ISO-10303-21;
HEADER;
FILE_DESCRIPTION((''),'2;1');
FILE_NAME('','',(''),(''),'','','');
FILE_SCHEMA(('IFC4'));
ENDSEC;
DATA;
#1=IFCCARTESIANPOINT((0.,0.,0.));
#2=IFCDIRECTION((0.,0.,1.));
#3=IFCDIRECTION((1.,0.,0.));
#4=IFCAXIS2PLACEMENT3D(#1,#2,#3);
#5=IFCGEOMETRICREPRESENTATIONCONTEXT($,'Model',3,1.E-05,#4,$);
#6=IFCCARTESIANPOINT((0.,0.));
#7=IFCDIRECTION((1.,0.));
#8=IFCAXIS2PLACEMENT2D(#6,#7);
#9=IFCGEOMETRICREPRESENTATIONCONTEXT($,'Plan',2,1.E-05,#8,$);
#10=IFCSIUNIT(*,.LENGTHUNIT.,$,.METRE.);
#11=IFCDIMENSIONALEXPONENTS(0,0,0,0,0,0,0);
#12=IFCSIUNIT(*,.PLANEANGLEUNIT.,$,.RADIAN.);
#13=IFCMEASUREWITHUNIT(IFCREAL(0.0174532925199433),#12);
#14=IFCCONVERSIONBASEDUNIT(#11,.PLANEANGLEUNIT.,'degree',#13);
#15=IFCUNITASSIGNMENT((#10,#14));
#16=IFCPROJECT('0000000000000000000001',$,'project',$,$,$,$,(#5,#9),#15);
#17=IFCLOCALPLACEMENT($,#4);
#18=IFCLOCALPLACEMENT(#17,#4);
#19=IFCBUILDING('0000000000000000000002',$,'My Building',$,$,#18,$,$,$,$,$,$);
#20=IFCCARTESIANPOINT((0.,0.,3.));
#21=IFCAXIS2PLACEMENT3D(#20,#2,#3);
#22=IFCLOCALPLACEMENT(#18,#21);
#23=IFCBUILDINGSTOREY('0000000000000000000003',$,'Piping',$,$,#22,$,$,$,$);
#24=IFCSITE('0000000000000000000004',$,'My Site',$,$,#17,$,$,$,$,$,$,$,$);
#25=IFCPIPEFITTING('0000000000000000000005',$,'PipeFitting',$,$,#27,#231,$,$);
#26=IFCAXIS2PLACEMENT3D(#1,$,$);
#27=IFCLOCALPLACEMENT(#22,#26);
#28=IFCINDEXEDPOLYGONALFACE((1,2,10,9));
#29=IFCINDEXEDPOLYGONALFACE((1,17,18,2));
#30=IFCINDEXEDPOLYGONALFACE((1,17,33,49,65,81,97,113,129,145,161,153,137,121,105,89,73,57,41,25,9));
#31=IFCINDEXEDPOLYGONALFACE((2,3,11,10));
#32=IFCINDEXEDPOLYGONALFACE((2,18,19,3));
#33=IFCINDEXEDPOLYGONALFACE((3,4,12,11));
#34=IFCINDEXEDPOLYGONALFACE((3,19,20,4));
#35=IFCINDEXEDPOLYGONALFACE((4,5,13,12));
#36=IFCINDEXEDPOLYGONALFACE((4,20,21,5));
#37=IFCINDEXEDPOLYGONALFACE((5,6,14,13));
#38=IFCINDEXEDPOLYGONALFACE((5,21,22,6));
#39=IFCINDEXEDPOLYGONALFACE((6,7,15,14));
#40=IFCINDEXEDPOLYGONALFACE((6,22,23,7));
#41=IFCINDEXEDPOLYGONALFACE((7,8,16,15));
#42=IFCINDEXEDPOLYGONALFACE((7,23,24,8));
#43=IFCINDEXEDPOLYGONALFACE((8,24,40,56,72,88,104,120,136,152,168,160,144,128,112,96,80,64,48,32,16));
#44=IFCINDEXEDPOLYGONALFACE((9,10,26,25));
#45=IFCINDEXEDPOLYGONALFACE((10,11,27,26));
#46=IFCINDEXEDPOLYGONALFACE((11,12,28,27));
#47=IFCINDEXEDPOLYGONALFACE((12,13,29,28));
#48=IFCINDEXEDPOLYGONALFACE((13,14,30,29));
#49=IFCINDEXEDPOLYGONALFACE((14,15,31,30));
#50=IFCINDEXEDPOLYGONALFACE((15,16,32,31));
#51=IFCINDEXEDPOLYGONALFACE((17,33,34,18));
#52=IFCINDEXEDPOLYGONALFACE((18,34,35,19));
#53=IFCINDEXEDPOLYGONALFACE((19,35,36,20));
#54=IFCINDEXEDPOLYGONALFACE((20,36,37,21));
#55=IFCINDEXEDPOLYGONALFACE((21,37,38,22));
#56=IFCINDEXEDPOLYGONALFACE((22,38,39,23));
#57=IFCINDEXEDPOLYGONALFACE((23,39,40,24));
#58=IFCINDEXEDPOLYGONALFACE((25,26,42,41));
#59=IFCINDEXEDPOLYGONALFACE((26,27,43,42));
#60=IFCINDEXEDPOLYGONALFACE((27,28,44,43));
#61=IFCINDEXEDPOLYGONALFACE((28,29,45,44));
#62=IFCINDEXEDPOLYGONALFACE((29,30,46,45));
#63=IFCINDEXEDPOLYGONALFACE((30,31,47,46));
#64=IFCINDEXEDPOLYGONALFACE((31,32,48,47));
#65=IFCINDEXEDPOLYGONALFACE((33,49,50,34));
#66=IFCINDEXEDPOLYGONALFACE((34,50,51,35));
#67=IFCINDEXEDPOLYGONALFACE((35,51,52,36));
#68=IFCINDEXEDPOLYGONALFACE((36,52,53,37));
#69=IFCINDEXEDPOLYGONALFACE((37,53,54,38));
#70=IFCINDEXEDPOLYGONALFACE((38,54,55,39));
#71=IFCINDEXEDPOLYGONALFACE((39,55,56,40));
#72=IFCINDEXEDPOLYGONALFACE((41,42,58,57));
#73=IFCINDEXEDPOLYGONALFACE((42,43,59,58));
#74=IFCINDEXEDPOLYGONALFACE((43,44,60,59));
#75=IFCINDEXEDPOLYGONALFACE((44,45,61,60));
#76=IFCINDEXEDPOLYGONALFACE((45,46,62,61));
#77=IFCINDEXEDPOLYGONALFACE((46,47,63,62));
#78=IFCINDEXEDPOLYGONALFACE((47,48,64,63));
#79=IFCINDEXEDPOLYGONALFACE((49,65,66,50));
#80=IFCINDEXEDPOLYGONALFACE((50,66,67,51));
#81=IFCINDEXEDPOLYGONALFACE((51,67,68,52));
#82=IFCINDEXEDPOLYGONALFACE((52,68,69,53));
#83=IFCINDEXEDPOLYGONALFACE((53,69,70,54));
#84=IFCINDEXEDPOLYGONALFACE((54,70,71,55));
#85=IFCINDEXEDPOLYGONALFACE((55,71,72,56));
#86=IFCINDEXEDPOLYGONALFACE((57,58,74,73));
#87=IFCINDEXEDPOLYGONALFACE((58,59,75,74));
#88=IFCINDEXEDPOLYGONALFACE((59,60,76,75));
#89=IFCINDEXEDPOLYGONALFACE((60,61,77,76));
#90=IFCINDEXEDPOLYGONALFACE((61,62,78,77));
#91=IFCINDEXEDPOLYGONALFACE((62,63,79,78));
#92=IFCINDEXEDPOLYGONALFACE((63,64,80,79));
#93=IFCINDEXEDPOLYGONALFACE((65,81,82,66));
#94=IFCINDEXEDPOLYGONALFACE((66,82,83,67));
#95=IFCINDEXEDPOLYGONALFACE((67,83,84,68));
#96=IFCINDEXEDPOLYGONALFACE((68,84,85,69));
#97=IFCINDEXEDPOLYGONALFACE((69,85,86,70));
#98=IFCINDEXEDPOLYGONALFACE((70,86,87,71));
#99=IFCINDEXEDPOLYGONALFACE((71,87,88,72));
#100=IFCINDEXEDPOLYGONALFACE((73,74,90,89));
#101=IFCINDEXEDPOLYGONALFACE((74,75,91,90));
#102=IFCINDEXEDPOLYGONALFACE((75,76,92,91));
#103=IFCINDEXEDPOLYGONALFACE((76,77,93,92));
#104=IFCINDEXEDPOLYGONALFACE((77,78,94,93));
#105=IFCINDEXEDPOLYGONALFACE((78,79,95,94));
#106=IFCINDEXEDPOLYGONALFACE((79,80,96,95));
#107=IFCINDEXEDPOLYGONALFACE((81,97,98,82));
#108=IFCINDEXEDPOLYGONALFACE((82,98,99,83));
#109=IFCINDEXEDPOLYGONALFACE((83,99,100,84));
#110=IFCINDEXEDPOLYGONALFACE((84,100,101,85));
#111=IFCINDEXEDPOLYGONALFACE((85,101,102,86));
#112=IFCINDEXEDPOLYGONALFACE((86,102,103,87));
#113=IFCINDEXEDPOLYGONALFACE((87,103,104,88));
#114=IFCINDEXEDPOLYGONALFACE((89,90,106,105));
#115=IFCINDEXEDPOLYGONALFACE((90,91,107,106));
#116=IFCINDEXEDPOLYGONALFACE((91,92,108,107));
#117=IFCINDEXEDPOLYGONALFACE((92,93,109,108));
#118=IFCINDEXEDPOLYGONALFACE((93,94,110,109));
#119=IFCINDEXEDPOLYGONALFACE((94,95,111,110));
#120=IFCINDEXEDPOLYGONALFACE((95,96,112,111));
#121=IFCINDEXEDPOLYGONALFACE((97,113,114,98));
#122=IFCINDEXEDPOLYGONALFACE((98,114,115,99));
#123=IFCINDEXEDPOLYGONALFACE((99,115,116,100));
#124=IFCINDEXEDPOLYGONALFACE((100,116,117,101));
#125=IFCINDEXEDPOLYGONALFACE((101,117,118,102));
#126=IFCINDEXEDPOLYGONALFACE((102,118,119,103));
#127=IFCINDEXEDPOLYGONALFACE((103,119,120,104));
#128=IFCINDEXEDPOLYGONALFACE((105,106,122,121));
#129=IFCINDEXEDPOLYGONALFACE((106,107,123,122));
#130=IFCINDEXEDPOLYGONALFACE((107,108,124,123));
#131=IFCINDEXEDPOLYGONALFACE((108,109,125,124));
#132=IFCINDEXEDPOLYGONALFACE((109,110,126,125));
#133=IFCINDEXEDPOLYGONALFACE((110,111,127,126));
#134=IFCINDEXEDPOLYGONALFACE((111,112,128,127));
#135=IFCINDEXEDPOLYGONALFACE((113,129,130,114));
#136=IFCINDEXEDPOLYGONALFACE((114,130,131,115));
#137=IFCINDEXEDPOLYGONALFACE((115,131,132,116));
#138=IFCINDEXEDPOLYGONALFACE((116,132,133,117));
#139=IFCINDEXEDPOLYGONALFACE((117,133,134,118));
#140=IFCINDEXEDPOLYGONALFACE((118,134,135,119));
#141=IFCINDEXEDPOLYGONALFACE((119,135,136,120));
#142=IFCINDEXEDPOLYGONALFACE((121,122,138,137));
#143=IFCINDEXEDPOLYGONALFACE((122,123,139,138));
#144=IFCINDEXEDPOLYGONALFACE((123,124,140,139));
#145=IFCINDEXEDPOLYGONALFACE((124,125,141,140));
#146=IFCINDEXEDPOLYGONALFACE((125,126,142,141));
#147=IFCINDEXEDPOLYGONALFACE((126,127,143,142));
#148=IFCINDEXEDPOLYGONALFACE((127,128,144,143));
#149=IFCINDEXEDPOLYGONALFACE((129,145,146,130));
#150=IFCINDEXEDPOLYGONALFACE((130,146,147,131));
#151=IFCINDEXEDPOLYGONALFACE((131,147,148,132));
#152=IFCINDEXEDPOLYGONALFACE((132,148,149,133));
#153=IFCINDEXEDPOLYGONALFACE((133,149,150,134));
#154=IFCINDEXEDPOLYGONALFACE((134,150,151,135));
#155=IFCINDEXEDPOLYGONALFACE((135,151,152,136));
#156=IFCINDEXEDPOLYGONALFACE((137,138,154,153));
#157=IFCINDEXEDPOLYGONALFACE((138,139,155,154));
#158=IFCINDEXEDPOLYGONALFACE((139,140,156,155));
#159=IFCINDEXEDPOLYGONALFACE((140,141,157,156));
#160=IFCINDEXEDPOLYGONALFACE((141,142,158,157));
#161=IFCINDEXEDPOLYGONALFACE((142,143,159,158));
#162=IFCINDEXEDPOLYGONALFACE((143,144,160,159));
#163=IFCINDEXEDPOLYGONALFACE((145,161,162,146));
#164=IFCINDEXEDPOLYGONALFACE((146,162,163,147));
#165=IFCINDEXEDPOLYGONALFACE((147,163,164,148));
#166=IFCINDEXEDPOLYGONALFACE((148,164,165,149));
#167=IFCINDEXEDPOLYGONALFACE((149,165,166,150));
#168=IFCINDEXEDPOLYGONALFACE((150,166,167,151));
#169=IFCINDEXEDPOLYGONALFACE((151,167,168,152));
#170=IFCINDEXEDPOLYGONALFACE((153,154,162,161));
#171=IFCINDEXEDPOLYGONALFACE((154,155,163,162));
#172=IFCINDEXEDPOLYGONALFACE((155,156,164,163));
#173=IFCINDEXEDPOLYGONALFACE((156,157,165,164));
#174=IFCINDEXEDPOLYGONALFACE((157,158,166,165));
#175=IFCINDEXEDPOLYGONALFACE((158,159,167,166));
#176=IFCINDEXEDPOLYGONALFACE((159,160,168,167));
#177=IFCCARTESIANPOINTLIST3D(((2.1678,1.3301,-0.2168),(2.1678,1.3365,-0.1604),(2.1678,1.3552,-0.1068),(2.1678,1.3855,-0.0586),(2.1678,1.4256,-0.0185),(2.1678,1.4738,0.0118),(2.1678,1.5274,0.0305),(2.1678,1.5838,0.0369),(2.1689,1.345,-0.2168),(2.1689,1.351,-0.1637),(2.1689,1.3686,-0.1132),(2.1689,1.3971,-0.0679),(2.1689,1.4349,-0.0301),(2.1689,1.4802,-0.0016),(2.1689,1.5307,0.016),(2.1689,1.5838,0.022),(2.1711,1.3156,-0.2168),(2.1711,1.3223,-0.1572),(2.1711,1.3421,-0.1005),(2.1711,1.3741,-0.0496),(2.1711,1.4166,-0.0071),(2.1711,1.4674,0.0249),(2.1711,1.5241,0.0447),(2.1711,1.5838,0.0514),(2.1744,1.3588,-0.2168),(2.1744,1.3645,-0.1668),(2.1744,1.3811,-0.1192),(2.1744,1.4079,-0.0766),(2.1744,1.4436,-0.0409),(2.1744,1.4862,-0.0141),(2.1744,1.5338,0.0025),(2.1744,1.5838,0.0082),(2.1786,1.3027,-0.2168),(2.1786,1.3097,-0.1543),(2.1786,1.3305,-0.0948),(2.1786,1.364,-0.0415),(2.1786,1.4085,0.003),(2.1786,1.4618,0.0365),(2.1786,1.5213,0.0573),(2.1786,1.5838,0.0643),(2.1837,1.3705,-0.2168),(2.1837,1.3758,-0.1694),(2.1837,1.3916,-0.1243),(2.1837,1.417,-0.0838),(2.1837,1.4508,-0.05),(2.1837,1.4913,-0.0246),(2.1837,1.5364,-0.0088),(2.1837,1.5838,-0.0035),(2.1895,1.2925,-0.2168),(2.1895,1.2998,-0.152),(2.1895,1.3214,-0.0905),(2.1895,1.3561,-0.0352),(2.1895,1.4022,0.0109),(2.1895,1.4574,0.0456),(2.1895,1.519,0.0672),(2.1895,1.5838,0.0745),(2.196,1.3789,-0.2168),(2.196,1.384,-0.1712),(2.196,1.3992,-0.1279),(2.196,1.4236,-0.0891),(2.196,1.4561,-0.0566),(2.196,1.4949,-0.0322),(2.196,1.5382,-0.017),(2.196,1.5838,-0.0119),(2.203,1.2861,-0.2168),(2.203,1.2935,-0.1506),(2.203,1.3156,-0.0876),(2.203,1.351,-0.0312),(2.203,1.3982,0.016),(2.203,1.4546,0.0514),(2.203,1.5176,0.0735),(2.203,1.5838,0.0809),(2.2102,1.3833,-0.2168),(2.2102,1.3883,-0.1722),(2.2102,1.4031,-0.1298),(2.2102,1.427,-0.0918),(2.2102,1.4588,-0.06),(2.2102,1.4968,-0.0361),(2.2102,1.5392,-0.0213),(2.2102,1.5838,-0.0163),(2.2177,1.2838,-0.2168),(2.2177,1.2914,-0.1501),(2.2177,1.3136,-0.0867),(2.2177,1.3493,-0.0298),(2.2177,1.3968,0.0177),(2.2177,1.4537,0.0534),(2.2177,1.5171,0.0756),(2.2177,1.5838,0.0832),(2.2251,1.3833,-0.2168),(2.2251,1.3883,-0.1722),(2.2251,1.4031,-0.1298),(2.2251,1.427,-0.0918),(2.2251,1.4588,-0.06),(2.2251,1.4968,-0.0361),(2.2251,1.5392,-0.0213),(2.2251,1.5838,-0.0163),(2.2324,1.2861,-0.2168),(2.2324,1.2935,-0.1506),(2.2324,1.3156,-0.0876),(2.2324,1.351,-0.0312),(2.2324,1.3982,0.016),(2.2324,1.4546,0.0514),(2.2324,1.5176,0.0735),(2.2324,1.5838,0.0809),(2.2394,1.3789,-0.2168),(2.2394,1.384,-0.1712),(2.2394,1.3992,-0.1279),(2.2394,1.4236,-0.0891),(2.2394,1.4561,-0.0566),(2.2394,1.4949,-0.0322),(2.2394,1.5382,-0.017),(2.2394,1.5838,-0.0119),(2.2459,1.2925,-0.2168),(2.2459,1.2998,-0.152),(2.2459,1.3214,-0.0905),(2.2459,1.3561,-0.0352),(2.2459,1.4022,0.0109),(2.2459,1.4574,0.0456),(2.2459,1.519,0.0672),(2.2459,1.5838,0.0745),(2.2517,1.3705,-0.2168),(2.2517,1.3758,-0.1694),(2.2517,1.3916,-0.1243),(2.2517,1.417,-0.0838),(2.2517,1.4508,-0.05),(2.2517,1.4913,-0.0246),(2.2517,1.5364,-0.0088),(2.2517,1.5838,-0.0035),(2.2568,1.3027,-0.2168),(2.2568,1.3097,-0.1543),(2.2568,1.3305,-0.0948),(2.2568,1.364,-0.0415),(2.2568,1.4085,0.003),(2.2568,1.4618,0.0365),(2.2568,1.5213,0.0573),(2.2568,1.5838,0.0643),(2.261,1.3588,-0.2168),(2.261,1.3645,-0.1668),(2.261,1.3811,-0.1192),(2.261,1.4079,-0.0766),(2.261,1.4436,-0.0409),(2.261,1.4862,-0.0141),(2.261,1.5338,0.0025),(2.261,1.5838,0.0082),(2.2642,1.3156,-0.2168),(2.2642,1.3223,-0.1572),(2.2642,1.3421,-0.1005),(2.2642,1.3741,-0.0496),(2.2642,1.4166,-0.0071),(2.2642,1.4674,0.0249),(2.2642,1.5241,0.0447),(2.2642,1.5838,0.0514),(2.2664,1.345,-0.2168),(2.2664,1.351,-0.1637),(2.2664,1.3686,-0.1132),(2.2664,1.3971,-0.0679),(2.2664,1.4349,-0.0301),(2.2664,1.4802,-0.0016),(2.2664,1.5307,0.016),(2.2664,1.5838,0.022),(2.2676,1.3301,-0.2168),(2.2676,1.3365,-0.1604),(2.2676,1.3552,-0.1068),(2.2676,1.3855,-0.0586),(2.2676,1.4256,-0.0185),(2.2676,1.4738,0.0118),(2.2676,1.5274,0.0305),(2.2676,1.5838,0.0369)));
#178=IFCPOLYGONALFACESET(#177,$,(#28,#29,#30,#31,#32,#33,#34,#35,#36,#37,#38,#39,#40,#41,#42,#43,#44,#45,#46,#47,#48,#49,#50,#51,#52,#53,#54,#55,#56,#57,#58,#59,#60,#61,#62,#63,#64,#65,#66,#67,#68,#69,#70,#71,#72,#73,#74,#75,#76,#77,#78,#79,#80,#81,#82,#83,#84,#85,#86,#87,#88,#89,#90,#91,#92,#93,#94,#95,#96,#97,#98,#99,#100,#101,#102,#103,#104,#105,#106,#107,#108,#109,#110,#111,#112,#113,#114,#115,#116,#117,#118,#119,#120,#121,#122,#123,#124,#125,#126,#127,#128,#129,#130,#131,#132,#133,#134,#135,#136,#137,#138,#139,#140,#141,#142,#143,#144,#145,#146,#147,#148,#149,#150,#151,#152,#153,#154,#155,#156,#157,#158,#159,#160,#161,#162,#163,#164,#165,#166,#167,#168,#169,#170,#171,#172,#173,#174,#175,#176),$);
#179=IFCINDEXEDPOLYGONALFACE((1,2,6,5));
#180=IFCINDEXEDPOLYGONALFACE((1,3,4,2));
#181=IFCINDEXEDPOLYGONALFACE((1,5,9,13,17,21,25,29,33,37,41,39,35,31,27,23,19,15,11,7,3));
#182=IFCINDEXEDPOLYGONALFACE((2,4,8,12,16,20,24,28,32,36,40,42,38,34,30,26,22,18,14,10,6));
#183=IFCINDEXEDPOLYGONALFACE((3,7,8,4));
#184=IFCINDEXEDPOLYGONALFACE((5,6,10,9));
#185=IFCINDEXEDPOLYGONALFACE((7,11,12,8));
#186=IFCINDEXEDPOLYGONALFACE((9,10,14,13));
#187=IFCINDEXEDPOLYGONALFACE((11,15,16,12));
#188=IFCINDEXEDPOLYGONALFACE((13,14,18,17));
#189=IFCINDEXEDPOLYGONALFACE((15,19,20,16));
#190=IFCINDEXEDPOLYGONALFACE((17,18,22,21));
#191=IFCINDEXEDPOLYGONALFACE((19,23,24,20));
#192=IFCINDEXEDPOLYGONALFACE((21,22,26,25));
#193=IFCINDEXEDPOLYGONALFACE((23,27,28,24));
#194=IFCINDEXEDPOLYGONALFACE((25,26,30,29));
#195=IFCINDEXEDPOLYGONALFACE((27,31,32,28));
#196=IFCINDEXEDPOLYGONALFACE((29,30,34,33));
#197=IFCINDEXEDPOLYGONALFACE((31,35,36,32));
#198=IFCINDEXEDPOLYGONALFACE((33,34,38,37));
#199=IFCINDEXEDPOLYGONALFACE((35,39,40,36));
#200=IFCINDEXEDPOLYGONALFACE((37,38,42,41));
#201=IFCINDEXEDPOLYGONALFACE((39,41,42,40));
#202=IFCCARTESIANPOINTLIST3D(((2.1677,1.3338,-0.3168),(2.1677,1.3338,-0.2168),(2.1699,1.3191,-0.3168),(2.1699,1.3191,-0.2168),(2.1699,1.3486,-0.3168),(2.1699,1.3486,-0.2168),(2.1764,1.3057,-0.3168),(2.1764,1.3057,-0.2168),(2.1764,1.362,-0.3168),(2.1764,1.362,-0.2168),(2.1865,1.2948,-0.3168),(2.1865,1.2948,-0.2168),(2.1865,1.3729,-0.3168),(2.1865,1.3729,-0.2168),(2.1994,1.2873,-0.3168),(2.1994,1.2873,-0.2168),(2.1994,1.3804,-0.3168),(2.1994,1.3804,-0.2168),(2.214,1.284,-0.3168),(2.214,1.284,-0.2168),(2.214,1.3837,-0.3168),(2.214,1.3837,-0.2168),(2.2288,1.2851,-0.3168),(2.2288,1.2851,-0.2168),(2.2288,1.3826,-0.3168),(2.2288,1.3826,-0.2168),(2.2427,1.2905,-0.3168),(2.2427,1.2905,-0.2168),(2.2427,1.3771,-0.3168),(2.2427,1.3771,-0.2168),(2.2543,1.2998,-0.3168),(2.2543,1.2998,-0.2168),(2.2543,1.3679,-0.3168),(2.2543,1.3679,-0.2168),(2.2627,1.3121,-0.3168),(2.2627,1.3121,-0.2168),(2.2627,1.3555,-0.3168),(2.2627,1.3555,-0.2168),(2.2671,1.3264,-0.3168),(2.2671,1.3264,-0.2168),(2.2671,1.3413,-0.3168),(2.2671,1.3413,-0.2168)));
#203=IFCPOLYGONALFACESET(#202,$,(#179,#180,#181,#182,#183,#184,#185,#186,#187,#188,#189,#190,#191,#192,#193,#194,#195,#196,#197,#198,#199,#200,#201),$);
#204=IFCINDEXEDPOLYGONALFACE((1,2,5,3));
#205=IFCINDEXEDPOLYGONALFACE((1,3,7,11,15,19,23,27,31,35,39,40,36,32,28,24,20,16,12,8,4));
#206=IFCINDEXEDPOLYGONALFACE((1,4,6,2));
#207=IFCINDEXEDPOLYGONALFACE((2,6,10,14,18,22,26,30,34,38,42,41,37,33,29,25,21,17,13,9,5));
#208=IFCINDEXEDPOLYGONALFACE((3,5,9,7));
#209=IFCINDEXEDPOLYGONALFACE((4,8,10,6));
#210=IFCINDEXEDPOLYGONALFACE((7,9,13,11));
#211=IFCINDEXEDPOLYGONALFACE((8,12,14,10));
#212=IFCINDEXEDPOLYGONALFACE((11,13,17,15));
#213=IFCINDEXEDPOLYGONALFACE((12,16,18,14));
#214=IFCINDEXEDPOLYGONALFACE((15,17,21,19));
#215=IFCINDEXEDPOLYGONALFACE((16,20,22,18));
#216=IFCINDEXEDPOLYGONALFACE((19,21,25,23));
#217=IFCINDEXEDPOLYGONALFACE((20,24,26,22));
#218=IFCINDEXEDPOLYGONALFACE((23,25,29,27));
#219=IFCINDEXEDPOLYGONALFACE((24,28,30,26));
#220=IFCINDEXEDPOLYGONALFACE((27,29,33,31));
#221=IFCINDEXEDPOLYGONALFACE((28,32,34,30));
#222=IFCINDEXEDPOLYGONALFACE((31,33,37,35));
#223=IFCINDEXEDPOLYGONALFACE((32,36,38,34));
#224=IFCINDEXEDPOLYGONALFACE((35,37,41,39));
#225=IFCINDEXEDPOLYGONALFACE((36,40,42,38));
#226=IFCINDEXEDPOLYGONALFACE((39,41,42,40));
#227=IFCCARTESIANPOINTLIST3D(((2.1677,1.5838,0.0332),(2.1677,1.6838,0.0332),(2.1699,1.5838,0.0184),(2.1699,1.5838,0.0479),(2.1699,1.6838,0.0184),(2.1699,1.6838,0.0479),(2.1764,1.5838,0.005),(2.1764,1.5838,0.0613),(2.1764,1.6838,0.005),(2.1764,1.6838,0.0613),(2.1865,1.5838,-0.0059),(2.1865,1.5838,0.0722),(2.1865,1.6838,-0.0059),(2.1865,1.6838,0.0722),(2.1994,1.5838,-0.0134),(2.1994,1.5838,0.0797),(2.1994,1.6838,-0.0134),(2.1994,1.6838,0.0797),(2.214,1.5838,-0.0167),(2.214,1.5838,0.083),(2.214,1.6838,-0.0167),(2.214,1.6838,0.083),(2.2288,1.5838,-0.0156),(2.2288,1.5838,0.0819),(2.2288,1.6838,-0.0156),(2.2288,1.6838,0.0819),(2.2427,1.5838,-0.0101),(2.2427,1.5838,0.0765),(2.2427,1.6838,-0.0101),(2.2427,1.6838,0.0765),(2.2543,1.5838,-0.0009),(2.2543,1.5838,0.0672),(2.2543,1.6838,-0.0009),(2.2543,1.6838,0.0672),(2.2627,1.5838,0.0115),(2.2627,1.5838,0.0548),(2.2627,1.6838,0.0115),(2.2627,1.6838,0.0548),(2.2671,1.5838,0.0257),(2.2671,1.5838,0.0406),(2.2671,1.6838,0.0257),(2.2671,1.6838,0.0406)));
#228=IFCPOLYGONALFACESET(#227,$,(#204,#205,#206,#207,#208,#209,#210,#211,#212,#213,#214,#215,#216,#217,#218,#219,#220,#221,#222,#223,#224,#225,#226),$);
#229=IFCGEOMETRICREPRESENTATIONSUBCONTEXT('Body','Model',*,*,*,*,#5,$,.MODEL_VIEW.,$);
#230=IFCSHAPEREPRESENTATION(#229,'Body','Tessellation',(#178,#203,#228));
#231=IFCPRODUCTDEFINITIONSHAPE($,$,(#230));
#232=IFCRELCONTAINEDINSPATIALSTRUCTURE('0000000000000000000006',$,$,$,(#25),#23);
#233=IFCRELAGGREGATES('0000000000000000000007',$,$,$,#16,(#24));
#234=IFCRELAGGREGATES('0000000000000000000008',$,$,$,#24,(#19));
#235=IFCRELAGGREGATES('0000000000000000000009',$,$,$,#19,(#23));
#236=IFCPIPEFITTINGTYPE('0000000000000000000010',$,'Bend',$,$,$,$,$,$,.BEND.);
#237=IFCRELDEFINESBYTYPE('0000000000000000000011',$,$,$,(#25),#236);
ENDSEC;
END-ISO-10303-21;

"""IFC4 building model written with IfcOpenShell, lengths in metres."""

from ifc_helpers import new_model, entity, si_unit, converted_unit, frame, origin_with_axes, origin_2d_with_axis, place, context, subcontext, project, spatial, circle, extrude, source, transform, mapped, type_object, type_shapes, element, save


model = new_model("IFC4")

# Units and contexts
model_context = context("Model", 3, precision=1e-05, world=origin_with_axes())
plan_context = context("Plan", 2, precision=1e-05, world=origin_2d_with_axis())
body_context = subcontext(model_context, "Body", "Model", "MODEL_VIEW")
ifc_project = project(units=[si_unit("LENGTHUNIT", "METRE"), converted_unit("PLANEANGLEUNIT", "degree", entity("IfcReal", 0.0174532925199433), si_unit("PLANEANGLEUNIT", "RADIAN"), dimensions=[0, 0, 0, 0, 0, 0, 0])], contexts=[model_context, plan_context])

# Site, building, storey
site_placement = place(None, origin_with_axes())
site = spatial("IfcSite", under=ifc_project, at=site_placement, Name="My Site")
building_placement = place(site_placement, origin_with_axes())
building = spatial("IfcBuilding", under=site, at=building_placement, Name="My Building")
storey_placement = place(building_placement, frame((0.0, 0.0, 3.0), z_axis=(0.0, 0.0, 1.0), x_axis=(1.0, 0.0, 0.0)))
storey = spatial("IfcBuildingStorey", under=building, at=storey_placement, Name="Piping")

# Pipe fitting
pipe_fitting_type = type_object("IfcPipeFittingType", Name="Bend", PredefinedType="BEND")
shared_shape = source(origin_with_axes(), body_context, "Body", "SolidModel", [
    entity("IfcSweptDiskSolid", entity("IfcIndexedPolyCurve", entity("IfcCartesianPointList3D", [[0.0, 0.0, -0.1], [0.0, 0.0732, -0.2768], [0.0, 0.25, -0.35]]), [entity("IfcArcIndex", [1, 2, 3])]), 0.05),
    extrude(circle(Radius=0.05), origin_with_axes(), (0.0, 0.0, -1.0), 0.1),
    extrude(circle(Radius=0.05), frame((0.0, 0.25, -0.35), z_axis=(0.0, 1.0, 0.0), x_axis=(1.0, 0.0, 0.0)), (0.0, 0.0, 1.0), 0.1),
])
type_shapes(pipe_fitting_type, [shared_shape])
for number, where, z_axis, x_axis, name in (
    (1, (2.2177, 1.3338, -0.3168), (0.0, 0.0, -1.0), (-1.0, 0.0, 0.0), "PipeFitting"),
):
    element("IfcPipeFitting", number, at=place(storey_placement, frame(where, z_axis=z_axis, x_axis=x_axis)), inside=storey, type_object=pipe_fitting_type, Name=name, context=body_context, shape_type="MappedRepresentation", body=[
        mapped(shared_shape, transform((0.0, 0.0, 0.0), x_axis=(1.0, 0.0, 0.0), y_axis=(0.0, 1.0, 0.0), z_axis=(0.0, 0.0, 1.0), scale=1.0)),
    ])

save(model, "model.ifc")
